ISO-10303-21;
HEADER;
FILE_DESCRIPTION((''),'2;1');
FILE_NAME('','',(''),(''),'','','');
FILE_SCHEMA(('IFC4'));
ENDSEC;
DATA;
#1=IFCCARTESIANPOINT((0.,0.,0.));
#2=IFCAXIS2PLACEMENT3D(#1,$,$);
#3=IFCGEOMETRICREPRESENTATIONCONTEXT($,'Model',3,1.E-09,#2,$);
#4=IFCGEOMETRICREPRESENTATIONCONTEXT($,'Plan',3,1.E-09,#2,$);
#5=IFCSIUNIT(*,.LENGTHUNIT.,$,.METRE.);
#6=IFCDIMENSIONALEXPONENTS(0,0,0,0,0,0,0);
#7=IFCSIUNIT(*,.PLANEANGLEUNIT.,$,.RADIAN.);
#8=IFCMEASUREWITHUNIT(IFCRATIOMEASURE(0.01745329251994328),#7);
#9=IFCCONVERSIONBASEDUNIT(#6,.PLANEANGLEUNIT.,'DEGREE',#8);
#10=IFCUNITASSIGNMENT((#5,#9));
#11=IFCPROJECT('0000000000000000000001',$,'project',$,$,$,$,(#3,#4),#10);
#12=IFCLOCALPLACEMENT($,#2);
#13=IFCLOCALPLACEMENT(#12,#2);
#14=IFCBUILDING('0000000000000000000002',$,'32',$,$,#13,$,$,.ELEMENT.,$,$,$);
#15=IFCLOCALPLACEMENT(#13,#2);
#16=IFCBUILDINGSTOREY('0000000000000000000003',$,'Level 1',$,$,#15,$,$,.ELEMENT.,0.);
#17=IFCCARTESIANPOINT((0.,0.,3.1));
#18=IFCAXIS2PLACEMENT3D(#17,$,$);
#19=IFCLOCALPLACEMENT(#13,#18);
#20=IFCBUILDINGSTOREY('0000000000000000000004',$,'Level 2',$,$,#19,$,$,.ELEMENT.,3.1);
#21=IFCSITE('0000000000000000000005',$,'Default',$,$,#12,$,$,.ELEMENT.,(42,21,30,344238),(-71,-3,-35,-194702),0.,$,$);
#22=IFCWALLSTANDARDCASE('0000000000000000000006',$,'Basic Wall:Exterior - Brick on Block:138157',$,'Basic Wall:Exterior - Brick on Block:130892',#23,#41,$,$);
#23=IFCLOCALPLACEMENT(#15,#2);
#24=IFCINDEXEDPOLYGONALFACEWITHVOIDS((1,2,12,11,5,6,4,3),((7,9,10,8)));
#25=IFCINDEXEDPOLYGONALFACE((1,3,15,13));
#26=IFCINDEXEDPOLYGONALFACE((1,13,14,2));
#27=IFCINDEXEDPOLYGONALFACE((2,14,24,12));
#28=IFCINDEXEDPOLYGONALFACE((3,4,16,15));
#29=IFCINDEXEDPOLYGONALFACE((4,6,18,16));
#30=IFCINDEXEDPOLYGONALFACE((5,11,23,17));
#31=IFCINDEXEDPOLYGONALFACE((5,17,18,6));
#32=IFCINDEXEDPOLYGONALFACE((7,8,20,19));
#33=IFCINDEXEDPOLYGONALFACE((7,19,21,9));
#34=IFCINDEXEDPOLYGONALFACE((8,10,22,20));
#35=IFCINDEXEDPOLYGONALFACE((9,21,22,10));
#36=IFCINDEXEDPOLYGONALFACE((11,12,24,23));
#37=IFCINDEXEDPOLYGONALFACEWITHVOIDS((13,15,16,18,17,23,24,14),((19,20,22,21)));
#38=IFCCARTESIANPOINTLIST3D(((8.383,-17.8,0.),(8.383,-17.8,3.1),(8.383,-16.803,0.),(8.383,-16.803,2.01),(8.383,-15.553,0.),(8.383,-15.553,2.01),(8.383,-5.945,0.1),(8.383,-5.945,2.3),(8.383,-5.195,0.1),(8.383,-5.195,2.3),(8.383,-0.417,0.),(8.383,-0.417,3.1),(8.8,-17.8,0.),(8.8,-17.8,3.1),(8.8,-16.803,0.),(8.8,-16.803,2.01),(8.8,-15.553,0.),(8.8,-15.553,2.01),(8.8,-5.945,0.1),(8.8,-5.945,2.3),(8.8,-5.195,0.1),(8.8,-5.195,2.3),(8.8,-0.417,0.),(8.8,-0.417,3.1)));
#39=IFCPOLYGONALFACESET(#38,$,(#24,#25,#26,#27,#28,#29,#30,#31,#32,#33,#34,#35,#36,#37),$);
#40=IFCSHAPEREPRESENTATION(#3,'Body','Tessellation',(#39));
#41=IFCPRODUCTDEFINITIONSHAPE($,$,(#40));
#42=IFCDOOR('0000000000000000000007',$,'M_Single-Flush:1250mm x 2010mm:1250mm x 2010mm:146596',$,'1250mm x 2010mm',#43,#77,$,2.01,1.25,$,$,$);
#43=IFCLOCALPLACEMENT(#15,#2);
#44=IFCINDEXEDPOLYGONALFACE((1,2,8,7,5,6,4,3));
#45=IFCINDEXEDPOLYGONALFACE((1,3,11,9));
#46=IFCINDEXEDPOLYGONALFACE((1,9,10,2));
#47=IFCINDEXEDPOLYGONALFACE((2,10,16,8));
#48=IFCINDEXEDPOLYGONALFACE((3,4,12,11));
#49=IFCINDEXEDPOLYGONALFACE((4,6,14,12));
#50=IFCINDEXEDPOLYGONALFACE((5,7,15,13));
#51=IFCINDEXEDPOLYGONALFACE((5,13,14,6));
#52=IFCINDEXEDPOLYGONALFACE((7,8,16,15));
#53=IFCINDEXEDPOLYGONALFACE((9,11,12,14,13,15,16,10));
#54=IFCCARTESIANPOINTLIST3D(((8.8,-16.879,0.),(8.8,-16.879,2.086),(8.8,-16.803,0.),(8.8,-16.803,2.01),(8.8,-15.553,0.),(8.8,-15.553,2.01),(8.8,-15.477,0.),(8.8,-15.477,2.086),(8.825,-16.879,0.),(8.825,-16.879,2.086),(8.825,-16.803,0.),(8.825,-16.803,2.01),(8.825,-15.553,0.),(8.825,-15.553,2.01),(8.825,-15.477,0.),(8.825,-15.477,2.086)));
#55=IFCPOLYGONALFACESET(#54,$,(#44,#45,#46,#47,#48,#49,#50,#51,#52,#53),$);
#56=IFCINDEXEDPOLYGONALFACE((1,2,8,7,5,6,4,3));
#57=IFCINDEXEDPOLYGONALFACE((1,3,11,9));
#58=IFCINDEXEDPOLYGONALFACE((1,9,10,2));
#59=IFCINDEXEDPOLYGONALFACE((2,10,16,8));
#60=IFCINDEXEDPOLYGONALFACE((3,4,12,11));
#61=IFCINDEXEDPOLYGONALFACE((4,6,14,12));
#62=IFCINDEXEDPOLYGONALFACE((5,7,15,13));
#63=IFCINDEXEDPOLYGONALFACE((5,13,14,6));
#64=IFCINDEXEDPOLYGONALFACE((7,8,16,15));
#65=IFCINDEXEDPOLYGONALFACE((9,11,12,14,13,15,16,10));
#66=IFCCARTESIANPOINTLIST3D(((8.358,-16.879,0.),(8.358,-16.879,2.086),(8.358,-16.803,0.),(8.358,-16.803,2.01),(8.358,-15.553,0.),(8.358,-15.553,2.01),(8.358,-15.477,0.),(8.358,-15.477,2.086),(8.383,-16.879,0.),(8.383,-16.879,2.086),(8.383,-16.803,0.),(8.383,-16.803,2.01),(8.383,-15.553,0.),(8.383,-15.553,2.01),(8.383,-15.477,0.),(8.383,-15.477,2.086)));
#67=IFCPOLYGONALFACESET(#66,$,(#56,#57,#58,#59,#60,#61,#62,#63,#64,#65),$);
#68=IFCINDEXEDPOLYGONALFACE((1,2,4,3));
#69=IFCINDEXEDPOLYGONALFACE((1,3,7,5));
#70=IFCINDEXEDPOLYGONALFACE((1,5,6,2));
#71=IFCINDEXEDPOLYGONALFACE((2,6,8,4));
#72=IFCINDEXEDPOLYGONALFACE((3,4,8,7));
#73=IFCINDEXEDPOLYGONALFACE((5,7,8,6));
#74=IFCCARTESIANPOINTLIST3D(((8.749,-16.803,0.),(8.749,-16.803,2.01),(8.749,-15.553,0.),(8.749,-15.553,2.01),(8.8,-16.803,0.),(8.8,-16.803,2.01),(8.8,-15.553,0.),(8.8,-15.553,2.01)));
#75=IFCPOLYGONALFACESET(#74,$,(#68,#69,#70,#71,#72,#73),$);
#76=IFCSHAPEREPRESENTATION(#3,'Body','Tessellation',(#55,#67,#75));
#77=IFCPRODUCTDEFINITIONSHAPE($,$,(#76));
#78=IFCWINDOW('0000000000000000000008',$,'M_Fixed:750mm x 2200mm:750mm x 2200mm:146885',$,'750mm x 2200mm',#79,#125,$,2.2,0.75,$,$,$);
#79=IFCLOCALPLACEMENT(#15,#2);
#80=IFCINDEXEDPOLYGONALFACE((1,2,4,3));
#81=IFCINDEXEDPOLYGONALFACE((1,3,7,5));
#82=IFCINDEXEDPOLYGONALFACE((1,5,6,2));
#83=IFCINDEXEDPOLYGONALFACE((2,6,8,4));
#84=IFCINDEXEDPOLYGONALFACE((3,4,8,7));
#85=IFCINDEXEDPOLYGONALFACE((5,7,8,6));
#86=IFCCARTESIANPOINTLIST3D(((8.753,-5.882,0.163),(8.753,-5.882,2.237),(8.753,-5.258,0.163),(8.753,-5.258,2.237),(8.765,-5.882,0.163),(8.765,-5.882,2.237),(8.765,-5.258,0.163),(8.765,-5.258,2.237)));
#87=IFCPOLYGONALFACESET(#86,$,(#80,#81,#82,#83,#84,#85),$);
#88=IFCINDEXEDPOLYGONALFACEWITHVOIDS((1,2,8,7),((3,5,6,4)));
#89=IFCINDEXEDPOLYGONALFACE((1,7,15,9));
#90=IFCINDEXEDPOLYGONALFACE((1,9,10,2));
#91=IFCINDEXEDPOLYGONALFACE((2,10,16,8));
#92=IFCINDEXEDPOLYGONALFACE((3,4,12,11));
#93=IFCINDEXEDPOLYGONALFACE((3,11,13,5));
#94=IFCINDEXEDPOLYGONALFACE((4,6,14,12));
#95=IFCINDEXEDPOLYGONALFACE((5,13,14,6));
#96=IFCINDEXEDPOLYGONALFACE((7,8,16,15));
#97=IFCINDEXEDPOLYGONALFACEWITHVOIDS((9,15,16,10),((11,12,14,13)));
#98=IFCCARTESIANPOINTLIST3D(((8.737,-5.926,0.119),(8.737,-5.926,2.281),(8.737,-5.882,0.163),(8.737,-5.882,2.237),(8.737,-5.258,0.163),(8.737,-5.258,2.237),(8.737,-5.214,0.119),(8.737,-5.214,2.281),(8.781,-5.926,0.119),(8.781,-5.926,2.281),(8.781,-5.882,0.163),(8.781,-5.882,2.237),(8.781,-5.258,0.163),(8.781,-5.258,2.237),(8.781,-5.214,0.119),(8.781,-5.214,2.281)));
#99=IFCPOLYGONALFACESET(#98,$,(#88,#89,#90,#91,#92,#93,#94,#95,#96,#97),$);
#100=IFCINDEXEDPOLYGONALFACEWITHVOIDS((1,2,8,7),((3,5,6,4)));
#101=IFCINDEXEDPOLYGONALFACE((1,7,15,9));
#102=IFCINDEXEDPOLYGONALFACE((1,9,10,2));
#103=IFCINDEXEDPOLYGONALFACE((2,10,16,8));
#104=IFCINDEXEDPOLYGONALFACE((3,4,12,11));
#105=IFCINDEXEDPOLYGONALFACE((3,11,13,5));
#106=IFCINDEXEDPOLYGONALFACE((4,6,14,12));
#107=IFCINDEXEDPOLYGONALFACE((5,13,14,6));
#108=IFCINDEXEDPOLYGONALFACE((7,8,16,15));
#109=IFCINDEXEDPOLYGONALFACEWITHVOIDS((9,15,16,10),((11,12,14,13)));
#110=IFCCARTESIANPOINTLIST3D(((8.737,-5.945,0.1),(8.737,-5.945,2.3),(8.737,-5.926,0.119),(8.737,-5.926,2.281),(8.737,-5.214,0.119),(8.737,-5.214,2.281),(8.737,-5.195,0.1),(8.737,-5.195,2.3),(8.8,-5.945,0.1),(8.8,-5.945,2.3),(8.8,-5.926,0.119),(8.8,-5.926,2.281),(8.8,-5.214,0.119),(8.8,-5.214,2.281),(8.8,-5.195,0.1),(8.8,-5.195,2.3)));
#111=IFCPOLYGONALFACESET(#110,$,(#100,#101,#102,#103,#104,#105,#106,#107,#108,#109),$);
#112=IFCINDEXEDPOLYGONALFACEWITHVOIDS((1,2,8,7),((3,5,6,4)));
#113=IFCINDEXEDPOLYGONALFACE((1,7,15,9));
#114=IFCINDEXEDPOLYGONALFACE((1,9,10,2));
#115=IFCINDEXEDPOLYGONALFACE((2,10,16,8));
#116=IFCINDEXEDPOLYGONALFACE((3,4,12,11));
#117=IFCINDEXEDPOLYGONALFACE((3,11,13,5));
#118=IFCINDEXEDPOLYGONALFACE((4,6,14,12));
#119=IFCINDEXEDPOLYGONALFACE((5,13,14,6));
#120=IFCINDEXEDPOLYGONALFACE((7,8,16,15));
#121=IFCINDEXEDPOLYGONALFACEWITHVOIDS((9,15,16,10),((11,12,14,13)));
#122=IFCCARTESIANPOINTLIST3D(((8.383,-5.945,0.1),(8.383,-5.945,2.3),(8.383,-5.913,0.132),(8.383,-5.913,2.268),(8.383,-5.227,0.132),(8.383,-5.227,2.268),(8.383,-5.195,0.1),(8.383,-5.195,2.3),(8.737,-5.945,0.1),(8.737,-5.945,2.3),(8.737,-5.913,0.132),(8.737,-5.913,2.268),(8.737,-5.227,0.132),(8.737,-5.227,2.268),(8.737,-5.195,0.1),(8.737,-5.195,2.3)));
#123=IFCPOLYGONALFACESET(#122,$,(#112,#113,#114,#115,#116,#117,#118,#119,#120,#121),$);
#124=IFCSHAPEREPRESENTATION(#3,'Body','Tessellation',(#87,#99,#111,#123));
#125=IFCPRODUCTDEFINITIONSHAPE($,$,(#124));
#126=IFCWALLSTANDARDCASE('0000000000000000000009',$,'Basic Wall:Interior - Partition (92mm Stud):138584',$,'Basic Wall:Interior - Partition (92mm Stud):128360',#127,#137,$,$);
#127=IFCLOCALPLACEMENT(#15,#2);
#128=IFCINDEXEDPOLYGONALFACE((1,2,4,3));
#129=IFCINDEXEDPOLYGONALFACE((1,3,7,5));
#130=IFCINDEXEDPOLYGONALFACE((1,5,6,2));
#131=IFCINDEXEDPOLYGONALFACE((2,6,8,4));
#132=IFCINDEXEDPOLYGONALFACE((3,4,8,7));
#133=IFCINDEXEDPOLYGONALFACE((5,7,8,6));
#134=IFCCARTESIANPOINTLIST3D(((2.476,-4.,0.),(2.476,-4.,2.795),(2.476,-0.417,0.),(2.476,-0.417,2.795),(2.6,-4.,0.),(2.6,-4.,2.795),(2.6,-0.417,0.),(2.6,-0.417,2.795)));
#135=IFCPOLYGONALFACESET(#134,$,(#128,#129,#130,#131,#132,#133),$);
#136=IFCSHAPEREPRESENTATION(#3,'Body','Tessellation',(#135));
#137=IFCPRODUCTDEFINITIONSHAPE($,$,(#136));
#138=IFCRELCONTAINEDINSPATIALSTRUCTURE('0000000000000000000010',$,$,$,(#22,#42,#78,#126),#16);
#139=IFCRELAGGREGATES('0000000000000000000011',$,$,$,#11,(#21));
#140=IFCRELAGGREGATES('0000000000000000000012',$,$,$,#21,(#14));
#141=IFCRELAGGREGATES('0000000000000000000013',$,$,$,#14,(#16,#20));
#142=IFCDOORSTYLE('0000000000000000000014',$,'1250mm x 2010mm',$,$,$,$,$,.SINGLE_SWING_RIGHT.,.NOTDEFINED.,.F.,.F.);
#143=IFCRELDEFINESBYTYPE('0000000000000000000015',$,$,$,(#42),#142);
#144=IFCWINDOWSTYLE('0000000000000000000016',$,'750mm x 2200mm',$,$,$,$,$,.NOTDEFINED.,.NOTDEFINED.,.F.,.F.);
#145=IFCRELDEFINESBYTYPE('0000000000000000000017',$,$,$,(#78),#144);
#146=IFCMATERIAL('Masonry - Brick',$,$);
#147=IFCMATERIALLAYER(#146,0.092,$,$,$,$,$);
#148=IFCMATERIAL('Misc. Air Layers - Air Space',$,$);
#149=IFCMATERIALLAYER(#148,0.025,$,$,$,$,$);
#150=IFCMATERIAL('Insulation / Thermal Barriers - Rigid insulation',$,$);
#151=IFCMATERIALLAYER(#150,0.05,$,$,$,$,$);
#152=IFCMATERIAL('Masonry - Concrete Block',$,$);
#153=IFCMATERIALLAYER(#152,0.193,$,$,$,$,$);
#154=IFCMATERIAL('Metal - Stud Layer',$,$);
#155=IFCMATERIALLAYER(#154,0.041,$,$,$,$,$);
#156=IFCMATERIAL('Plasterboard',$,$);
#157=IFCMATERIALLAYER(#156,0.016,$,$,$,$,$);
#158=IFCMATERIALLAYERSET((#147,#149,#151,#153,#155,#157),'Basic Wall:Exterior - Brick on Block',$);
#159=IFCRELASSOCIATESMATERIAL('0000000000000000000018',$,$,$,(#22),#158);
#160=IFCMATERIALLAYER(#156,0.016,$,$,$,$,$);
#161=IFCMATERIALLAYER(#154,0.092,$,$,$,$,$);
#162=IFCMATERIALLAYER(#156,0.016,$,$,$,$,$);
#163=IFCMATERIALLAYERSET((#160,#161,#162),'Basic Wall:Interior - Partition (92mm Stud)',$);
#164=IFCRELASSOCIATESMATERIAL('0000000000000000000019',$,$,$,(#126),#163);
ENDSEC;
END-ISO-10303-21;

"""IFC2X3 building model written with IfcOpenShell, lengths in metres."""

from ifc_helpers import new_model, entity, si_unit, converted_unit, frame, frame_2d, origin, origin_2d_with_axis, place, context, project, spatial, polyline, rectangle, outline, extrude, source, transform, mapped, material, layer, layer_set, layer_usage, type_object, type_shapes, element, fill, save


model = new_model("IFC2X3")

# Units and contexts
model_context = context("Model", 3, precision=1e-09, world=origin())
plan_context = context("Plan", 3, precision=1e-09, world=origin())
ifc_project = project(units=[si_unit("LENGTHUNIT", "METRE"), converted_unit("PLANEANGLEUNIT", "DEGREE", entity("IfcRatioMeasure", 0.01745329251994328), si_unit("PLANEANGLEUNIT", "RADIAN"), dimensions=[0, 0, 0, 0, 0, 0, 0])], contexts=[model_context, plan_context])

# Site, building, storey
site_placement = place(None, origin())
site = spatial("IfcSite", under=ifc_project, at=site_placement, Name="Default", CompositionType="ELEMENT", RefLatitude=(42, 21, 30, 344238), RefLongitude=(-71, -3, -35, -194702), RefElevation=0.0)
building_placement = place(site_placement, origin())
building = spatial("IfcBuilding", under=site, at=building_placement, Name="32", CompositionType="ELEMENT")
storey_1_placement = place(building_placement, origin())
storey_1 = spatial("IfcBuildingStorey", under=building, at=storey_1_placement, Name="Level 1", CompositionType="ELEMENT", Elevation=0.0)

# Shared definitions
ifc_material_1 = material(Name="Masonry - Brick")
ifc_layer_1 = layer(ifc_material_1, 0.092)
ifc_material_2 = material(Name="Misc. Air Layers - Air Space")
ifc_layer_2 = layer(ifc_material_2, 0.025)
ifc_material_3 = material(Name="Insulation / Thermal Barriers - Rigid insulation")
ifc_layer_3 = layer(ifc_material_3, 0.05)
ifc_material_4 = material(Name="Masonry - Concrete Block")
ifc_layer_4 = layer(ifc_material_4, 0.193)
ifc_material_5 = material(Name="Metal - Stud Layer")
ifc_layer_5 = layer(ifc_material_5, 0.041)
ifc_material_6 = material(Name="Plasterboard")
ifc_layer_6 = layer(ifc_material_6, 0.016)
ifc_layer_set_1 = layer_set([ifc_layer_1, ifc_layer_2, ifc_layer_3, ifc_layer_4, ifc_layer_5, ifc_layer_6], Name="Basic Wall:Exterior - Brick on Block")

# Wall, openings, door, window
ifc_layer_usage_1 = layer_usage(ifc_layer_set_1, "AXIS2", "NEGATIVE", 0.2085)
wall_1_placement = place(storey_1_placement, frame((8.5915, -0.417, 0.0), z_axis=(0.0, 0.0, 1.0), x_axis=(0.0, -1.0, 0.0)))
wall_1 = element("IfcWallStandardCase", 1, at=wall_1_placement, inside=storey_1, material=ifc_layer_usage_1, Name="Basic Wall:Exterior - Brick on Block:138157", ObjectType="Basic Wall:Exterior - Brick on Block:130892", context=model_context, shape_type="SweptSolid", body=[
    extrude(rectangle(XDim=17.383, YDim=0.417, at=frame_2d((8.6915, 0.0), x_axis=(-1.0, 0.0))), origin(), (0.0, 0.0, 1.0), 3.1),
])
opening_1_placement = place(wall_1_placement, frame((15.136, -0.2085, 0.0)))
opening_1 = element("IfcOpeningElement", 2, at=opening_1_placement, cuts=wall_1, ObjectType="Opening", context=model_context, shape_type="SweptSolid", body=[
    extrude(rectangle(XDim=1.25, YDim=2.01, at=frame_2d((1.005, 0.625), x_axis=(0.0, 1.0))), frame((0.0, 0.0, 0.0), z_axis=(0.0, 1.0, 0.0), x_axis=(0.0, 0.0, 1.0)), (0.0, 0.0, 1.0), 0.417),
])
opening_2_placement = place(wall_1_placement, frame((4.778, -0.2085, 0.1)))
opening_2 = element("IfcOpeningElement", 3, at=opening_2_placement, cuts=wall_1, ObjectType="Opening", context=model_context, shape_type="SweptSolid", body=[
    extrude(rectangle(XDim=2.2, YDim=0.75, at=frame_2d((1.1, 0.375), x_axis=(1.0, 0.0))), frame((0.0, 0.0, 0.0), z_axis=(0.0, 1.0, 0.0), x_axis=(0.0, 0.0, 1.0)), (0.0, 0.0, 1.0), 0.417),
])
door_style_1 = type_object("IfcDoorStyle", Name="1250mm x 2010mm", ConstructionType="NOTDEFINED", OperationType="SINGLE_SWING_RIGHT", ParameterTakesPrecedence=False, Sizeable=False)
shared_shape_1 = source(origin(), model_context, "Body", "SweptSolid", [
    extrude(outline(polyline([(-0.701, -1.062), (0.701, -1.062), (0.701, 1.024), (0.625, 1.024), (0.625, -0.986), (-0.625, -0.986), (-0.625, 1.024), (-0.701, 1.024), (-0.701, -1.062)])), frame((0.625, 0.417, 1.024), z_axis=(0.0, 1.0, 0.0), x_axis=(1.0, 0.0, 0.0)), (0.0, 0.0, 1.0), 0.025),
    extrude(outline(polyline([(-1.062, -0.701), (1.024, -0.701), (1.024, -0.625), (-0.986, -0.625), (-0.986, 0.625), (1.024, 0.625), (1.024, 0.701), (-1.062, 0.701), (-1.062, -0.701)])), frame((0.625, -0.025, 1.024), z_axis=(0.0, 1.0, 0.0), x_axis=(0.0, 0.0, -1.0)), (0.0, 0.0, 1.0), 0.025),
    extrude(rectangle(XDim=0.051, YDim=1.25, at=origin_2d_with_axis()), frame((0.625, 0.3915, 0.0), z_axis=(0.0, 0.0, 1.0), x_axis=(0.0, 1.0, 0.0)), (0.0, 0.0, 1.0), 2.01),
])
type_shapes(door_style_1, [shared_shape_1])
door_1_placement = place(opening_1_placement, origin())
door_1 = element("IfcDoor", 4, at=door_1_placement, inside=storey_1, type_object=door_style_1, Name="M_Single-Flush:1250mm x 2010mm:1250mm x 2010mm:146596", ObjectType="1250mm x 2010mm", OverallHeight=2.01, OverallWidth=1.25, context=model_context, shape_type="MappedRepresentation", body=[
    mapped(shared_shape_1, transform((0.0, 0.0, 0.0), scale=1.0)),
])
fill(opening_1, door_1)
window_style_1 = type_object("IfcWindowStyle", Name="750mm x 2200mm", ConstructionType="NOTDEFINED", OperationType="NOTDEFINED", ParameterTakesPrecedence=False, Sizeable=False)
shared_shape_2 = source(origin(), model_context, "Body", "SweptSolid", [
    extrude(rectangle(XDim=0.012, YDim=0.624, at=origin_2d_with_axis()), frame((0.375, 0.376, 0.063), z_axis=(0.0, 0.0, 1.0), x_axis=(0.0, -1.0, 0.0)), (0.0, 0.0, 1.0), 2.074),
    extrude(outline(polyline([(-0.356, -1.081), (0.356, -1.081), (0.356, 1.081), (-0.356, 1.081), (-0.356, -1.081)]), holes=[polyline([(-0.312, -1.037), (-0.312, 1.037), (0.312, 1.037), (0.312, -1.037), (-0.312, -1.037)])]), frame((0.375, 0.354, 1.1), z_axis=(0.0, 1.0, 0.0), x_axis=(1.0, 0.0, 0.0)), (0.0, 0.0, 1.0), 0.044),
    extrude(outline(polyline([(-0.375, -1.1), (0.375, -1.1), (0.375, 1.1), (-0.375, 1.1), (-0.375, -1.1)]), holes=[polyline([(-0.356, -1.081), (-0.356, 1.081), (0.356, 1.081), (0.356, -1.081), (-0.356, -1.081)])]), frame((0.375, 0.354, 1.1), z_axis=(0.0, 1.0, 0.0), x_axis=(1.0, 0.0, 0.0)), (0.0, 0.0, 1.0), 0.063),
    extrude(outline(polyline([(-0.375, -1.1), (0.375, -1.1), (0.375, 1.1), (-0.375, 1.1), (-0.375, -1.1)]), holes=[polyline([(-0.343, -1.068), (-0.343, 1.068), (0.343, 1.068), (0.343, -1.068), (-0.343, -1.068)])]), frame((0.375, 0.0, 1.1), z_axis=(0.0, 1.0, 0.0), x_axis=(1.0, 0.0, 0.0)), (0.0, 0.0, 1.0), 0.354),
])
type_shapes(window_style_1, [shared_shape_2])
window_1_placement = place(opening_2_placement, origin())
window_1 = element("IfcWindow", 5, at=window_1_placement, inside=storey_1, type_object=window_style_1, Name="M_Fixed:750mm x 2200mm:750mm x 2200mm:146885", ObjectType="750mm x 2200mm", OverallHeight=2.2, OverallWidth=0.75, context=model_context, shape_type="MappedRepresentation", body=[
    mapped(shared_shape_2, transform((0.0, 0.0, 0.0), scale=1.0)),
])
fill(opening_2, window_1)

# Wall
ifc_layer_7 = layer(ifc_material_6, 0.016)
ifc_layer_8 = layer(ifc_material_5, 0.092)
ifc_layer_9 = layer(ifc_material_6, 0.016)
ifc_layer_set_2 = layer_set([ifc_layer_7, ifc_layer_8, ifc_layer_9], Name="Basic Wall:Interior - Partition (92mm Stud)")
ifc_layer_usage_2 = layer_usage(ifc_layer_set_2, "AXIS2", "NEGATIVE", 0.062)
wall_2_placement = place(storey_1_placement, frame((2.538, -0.417, 0.0), z_axis=(0.0, 0.0, 1.0), x_axis=(0.0, -1.0, 0.0)))
element("IfcWallStandardCase", 6, at=wall_2_placement, inside=storey_1, material=ifc_layer_usage_2, Name="Basic Wall:Interior - Partition (92mm Stud):138584", ObjectType="Basic Wall:Interior - Partition (92mm Stud):128360", context=model_context, shape_type="SweptSolid", body=[
    extrude(rectangle(XDim=3.583, YDim=0.124, at=frame_2d((1.7915, 0.0), x_axis=(-1.0, 0.0))), origin(), (0.0, 0.0, 1.0), 2.795),
])

# Shared definitions
storey_2_placement = place(building_placement, frame((0.0, 0.0, 3.1)))
storey_2 = spatial("IfcBuildingStorey", under=building, at=storey_2_placement, Name="Level 2", CompositionType="ELEMENT", Elevation=3.1)

save(model, "model.ifc")
